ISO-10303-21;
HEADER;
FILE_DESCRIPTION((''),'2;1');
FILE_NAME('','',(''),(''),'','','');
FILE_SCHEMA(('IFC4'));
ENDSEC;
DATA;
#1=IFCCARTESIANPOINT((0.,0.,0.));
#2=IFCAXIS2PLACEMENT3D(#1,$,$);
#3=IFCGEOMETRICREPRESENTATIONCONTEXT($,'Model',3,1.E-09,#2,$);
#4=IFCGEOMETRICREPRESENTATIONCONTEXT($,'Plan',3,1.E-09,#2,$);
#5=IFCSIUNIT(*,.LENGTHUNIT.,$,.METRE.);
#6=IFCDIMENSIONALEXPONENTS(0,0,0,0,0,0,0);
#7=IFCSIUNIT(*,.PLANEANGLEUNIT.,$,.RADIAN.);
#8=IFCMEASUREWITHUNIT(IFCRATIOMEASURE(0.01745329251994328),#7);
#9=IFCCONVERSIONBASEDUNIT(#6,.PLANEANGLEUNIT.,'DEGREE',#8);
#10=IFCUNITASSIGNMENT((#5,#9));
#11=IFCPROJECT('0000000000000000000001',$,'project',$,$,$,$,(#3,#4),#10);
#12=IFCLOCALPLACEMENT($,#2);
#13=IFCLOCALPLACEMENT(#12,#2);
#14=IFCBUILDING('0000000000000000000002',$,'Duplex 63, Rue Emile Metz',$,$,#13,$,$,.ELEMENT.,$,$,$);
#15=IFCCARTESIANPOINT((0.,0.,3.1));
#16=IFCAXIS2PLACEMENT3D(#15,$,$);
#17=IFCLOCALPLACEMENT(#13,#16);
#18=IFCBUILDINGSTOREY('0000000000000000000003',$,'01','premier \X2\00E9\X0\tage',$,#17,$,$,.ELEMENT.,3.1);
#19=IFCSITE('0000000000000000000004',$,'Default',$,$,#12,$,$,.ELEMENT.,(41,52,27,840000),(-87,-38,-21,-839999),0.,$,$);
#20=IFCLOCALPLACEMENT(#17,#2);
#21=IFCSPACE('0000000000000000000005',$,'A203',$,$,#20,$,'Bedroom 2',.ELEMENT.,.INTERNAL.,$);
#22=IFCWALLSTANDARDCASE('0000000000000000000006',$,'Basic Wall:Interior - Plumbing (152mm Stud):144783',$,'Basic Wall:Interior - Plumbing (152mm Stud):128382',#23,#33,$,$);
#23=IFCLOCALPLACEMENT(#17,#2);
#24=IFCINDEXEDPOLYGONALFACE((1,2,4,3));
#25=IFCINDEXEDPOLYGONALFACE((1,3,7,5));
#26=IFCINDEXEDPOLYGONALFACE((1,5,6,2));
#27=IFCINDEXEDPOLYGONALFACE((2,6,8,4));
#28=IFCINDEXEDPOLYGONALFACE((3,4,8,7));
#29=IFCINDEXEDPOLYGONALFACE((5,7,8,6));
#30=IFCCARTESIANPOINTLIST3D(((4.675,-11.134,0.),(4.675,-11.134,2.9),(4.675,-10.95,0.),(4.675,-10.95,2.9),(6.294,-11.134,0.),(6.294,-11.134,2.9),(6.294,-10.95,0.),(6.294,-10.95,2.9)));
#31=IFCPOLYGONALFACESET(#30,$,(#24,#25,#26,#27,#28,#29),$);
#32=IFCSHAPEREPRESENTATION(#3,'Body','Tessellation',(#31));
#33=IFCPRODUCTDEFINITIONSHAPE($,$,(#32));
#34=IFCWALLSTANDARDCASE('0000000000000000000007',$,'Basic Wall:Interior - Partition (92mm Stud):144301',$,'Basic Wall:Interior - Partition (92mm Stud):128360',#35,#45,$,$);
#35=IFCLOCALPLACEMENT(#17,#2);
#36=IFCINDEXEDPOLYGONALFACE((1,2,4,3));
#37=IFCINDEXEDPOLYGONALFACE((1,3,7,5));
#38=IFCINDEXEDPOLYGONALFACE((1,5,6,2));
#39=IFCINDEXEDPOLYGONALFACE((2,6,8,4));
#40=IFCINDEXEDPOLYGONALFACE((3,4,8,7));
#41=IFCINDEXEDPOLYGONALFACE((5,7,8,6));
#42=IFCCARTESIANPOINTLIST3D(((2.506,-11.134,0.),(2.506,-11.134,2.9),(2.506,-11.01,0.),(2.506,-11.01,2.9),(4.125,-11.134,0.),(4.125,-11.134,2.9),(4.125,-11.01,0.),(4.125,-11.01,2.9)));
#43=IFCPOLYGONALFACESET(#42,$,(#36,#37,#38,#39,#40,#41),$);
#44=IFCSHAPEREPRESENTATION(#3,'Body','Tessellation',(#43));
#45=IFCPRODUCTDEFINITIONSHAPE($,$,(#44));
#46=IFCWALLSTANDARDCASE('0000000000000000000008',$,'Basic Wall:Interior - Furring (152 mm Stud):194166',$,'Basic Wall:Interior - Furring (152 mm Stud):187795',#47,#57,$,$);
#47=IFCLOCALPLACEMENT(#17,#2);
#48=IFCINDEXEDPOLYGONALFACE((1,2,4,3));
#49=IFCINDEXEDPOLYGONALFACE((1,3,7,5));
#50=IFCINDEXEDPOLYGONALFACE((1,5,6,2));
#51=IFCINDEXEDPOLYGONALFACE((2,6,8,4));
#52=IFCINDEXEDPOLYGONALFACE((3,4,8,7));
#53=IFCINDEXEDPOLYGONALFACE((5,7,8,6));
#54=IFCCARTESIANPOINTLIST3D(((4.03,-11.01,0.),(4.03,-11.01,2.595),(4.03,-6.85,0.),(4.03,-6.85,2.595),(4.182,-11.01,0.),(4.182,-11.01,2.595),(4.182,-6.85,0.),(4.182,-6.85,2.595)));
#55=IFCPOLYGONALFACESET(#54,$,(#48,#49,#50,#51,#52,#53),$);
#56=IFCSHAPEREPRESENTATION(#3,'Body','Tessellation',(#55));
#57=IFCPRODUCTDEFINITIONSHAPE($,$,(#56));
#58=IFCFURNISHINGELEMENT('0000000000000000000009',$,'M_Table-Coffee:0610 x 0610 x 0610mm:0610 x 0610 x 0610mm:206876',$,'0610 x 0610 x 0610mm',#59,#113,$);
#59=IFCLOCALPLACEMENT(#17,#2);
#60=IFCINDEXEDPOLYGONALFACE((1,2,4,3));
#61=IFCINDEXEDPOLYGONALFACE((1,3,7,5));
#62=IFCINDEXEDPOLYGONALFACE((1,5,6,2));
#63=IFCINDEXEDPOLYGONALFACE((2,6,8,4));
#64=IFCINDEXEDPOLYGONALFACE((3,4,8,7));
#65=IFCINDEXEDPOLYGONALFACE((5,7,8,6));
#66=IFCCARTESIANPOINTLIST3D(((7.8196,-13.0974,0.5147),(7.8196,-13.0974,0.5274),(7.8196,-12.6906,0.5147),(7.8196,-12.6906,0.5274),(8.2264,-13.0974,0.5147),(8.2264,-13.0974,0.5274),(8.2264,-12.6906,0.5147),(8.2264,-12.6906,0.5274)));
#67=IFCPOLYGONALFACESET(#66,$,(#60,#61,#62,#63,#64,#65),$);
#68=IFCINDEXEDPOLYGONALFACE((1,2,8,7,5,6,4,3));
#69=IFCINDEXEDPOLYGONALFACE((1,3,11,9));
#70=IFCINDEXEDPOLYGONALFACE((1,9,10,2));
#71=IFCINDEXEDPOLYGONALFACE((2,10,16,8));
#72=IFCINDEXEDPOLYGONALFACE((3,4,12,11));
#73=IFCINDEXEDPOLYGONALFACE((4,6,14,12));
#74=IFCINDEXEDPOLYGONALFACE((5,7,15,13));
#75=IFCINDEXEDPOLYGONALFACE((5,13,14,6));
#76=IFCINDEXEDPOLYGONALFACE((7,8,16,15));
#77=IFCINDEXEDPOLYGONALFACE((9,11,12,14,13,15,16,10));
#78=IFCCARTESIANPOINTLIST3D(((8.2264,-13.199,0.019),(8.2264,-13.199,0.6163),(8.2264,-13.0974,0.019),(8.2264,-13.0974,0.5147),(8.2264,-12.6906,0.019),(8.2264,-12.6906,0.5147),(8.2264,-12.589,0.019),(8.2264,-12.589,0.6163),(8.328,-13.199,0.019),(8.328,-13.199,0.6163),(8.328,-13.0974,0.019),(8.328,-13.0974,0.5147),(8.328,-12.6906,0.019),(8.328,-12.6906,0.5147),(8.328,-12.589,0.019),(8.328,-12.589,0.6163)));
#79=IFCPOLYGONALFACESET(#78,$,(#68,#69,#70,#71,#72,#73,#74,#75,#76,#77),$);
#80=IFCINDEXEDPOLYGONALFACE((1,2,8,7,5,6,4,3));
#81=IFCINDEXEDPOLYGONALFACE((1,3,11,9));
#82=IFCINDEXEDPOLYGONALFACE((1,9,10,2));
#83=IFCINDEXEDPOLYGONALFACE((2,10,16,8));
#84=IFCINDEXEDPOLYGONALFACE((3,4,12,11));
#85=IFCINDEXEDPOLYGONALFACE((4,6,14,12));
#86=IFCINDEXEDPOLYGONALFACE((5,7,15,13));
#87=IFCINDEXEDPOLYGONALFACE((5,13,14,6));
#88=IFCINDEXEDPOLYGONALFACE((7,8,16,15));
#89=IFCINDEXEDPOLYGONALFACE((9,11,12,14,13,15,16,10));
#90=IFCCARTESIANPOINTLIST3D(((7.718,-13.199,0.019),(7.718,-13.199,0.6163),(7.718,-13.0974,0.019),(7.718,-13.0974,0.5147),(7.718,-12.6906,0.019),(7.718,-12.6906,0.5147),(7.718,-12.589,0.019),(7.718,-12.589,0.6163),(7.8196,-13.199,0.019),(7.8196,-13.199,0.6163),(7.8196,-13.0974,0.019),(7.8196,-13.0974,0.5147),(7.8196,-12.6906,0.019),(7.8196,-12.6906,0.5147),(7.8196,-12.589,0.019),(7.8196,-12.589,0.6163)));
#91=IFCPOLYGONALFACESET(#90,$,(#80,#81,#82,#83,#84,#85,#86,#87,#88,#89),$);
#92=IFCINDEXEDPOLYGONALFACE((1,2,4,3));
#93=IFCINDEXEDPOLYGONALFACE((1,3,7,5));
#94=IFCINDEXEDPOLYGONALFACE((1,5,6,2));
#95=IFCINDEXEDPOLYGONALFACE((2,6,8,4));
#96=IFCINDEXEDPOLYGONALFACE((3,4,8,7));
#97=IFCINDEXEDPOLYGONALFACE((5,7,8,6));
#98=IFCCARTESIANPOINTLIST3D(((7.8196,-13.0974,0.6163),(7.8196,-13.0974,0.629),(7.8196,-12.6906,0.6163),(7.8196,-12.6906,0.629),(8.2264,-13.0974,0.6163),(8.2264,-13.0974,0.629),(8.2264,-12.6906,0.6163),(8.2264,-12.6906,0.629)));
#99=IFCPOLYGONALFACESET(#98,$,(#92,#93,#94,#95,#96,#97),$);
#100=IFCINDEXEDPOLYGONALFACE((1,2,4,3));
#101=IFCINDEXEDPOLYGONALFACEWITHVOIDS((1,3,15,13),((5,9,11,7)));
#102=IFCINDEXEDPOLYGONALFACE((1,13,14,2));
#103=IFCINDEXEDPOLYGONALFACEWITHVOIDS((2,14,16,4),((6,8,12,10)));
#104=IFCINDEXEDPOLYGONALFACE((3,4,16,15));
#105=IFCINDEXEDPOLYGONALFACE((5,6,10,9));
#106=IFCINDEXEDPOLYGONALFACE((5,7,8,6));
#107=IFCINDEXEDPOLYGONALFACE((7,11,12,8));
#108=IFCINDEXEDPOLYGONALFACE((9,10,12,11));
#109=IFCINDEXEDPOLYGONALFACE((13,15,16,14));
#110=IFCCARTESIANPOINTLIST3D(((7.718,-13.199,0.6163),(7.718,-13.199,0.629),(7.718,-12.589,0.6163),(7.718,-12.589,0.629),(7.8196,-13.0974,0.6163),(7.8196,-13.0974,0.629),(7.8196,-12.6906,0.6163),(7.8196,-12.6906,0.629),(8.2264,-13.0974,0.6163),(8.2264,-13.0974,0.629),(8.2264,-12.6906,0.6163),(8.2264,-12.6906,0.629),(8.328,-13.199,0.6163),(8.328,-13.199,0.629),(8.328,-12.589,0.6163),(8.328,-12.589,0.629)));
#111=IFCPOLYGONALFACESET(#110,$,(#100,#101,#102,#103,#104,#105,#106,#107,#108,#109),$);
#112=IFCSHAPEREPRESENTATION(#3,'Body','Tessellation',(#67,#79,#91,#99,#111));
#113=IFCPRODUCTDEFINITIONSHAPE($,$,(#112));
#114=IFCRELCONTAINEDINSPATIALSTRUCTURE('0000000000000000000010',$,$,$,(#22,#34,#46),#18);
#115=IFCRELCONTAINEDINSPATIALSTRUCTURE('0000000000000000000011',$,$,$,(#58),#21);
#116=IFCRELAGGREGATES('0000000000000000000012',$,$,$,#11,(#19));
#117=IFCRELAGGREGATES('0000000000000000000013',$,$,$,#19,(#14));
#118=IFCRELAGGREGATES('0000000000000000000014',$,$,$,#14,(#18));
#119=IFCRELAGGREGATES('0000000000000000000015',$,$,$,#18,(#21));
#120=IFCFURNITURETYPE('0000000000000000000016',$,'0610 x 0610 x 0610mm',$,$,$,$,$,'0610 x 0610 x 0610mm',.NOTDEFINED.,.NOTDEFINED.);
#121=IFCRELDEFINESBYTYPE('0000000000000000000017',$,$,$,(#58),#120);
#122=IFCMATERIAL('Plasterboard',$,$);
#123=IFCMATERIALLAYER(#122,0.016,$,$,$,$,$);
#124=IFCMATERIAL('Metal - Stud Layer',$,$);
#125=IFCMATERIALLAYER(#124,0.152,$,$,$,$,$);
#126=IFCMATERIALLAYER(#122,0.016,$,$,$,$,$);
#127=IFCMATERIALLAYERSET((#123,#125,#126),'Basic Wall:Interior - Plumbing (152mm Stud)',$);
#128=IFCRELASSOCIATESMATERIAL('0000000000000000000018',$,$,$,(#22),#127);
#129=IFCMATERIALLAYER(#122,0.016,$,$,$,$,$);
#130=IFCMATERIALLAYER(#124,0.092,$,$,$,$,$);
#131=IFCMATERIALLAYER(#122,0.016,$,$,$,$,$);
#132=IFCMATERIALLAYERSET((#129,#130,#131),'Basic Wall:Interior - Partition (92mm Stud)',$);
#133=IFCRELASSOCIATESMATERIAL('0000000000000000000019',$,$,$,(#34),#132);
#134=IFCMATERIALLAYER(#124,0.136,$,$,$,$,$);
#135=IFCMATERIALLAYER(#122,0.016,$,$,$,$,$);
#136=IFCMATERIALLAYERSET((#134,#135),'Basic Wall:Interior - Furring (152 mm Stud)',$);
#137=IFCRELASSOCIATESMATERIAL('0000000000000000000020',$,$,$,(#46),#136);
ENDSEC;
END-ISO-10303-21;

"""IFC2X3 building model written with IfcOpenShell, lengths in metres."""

from ifc_helpers import new_model, entity, si_unit, converted_unit, frame, frame_2d, origin, origin_2d_with_axis, place, context, project, spatial, polyline, rectangle, outline, extrude, source, transform, mapped, material, layer, layer_set, layer_usage, type_object, type_shapes, element, save


model = new_model("IFC2X3")

# Units and contexts
model_context = context("Model", 3, precision=1e-09, world=origin())
plan_context = context("Plan", 3, precision=1e-09, world=origin())
ifc_project = project(units=[si_unit("LENGTHUNIT", "METRE"), converted_unit("PLANEANGLEUNIT", "DEGREE", entity("IfcRatioMeasure", 0.01745329251994328), si_unit("PLANEANGLEUNIT", "RADIAN"), dimensions=[0, 0, 0, 0, 0, 0, 0])], contexts=[model_context, plan_context])

# Site, building, storey
site_placement = place(None, origin())
site = spatial("IfcSite", under=ifc_project, at=site_placement, Name="Default", CompositionType="ELEMENT", RefLatitude=(41, 52, 27, 840000), RefLongitude=(-87, -38, -21, -839999), RefElevation=0.0)
building_placement = place(site_placement, origin())
building = spatial("IfcBuilding", under=site, at=building_placement, Name="Duplex 63, Rue Emile Metz", CompositionType="ELEMENT")
storey_placement = place(building_placement, frame((0.0, 0.0, 3.1)))
storey = spatial("IfcBuildingStorey", under=building, at=storey_placement, Name="01", Description="premier étage", CompositionType="ELEMENT", Elevation=3.1)

# Shared definitions
ifc_material_1 = material(Name="Plasterboard")
ifc_layer_1 = layer(ifc_material_1, 0.016)
ifc_material_2 = material(Name="Metal - Stud Layer")
ifc_layer_2 = layer(ifc_material_2, 0.092)
ifc_layer_3 = layer(ifc_material_1, 0.016)
ifc_layer_set_1 = layer_set([ifc_layer_1, ifc_layer_2, ifc_layer_3], Name="Basic Wall:Interior - Partition (92mm Stud)")
ifc_layer_usage_1 = layer_usage(ifc_layer_set_1, "AXIS2", "NEGATIVE", 0.062)

# Walls
ifc_layer_4 = layer(ifc_material_1, 0.016)
ifc_layer_5 = layer(ifc_material_2, 0.152)
ifc_layer_6 = layer(ifc_material_1, 0.016)
ifc_layer_set_2 = layer_set([ifc_layer_4, ifc_layer_5, ifc_layer_6], Name="Basic Wall:Interior - Plumbing (152mm Stud)")
ifc_layer_usage_2 = layer_usage(ifc_layer_set_2, "AXIS2", "NEGATIVE", 0.092)
wall_1_placement = place(storey_placement, frame((6.294, -11.042, 0.0), z_axis=(0.0, 0.0, 1.0), x_axis=(-1.0, 0.0, 0.0)))
element("IfcWallStandardCase", 1, at=wall_1_placement, inside=storey, material=ifc_layer_usage_2, Name="Basic Wall:Interior - Plumbing (152mm Stud):144783", ObjectType="Basic Wall:Interior - Plumbing (152mm Stud):128382", context=model_context, shape_type="SweptSolid", body=[
    extrude(rectangle(XDim=1.619, YDim=0.184, at=frame_2d((0.8095, 0.0), x_axis=(-1.0, 0.0))), origin(), (0.0, 0.0, 1.0), 2.9),
])
wall_2_placement = place(storey_placement, frame((4.125, -11.072, 0.0), z_axis=(0.0, 0.0, 1.0), x_axis=(-1.0, 0.0, 0.0)))
element("IfcWallStandardCase", 2, at=wall_2_placement, inside=storey, material=ifc_layer_usage_1, Name="Basic Wall:Interior - Partition (92mm Stud):144301", ObjectType="Basic Wall:Interior - Partition (92mm Stud):128360", context=model_context, shape_type="SweptSolid", body=[
    extrude(rectangle(XDim=1.619, YDim=0.124, at=frame_2d((0.8095, 0.0), x_axis=(-1.0, 0.0))), origin(), (0.0, 0.0, 1.0), 2.9),
])
ifc_layer_7 = layer(ifc_material_2, 0.136)
ifc_layer_8 = layer(ifc_material_1, 0.016)
ifc_layer_set_3 = layer_set([ifc_layer_7, ifc_layer_8], Name="Basic Wall:Interior - Furring (152 mm Stud)")
ifc_layer_usage_3 = layer_usage(ifc_layer_set_3, "AXIS2", "POSITIVE", -0.076)
wall_3_placement = place(storey_placement, frame((4.106, -11.01, 0.0), z_axis=(0.0, 0.0, 1.0), x_axis=(0.0, 1.0, 0.0)))
element("IfcWallStandardCase", 3, at=wall_3_placement, inside=storey, material=ifc_layer_usage_3, Name="Basic Wall:Interior - Furring (152 mm Stud):194166", ObjectType="Basic Wall:Interior - Furring (152 mm Stud):187795", context=model_context, shape_type="SweptSolid", body=[
    extrude(rectangle(XDim=4.16, YDim=0.152, at=frame_2d((2.08, 0.0), x_axis=(-1.0, 0.0))), origin(), (0.0, 0.0, 1.0), 2.595),
])

# Shared definitions
space_placement = place(storey_placement, origin())
space = spatial("IfcSpace", under=storey, at=space_placement, Name="A203", LongName="Bedroom 2", CompositionType="ELEMENT", InteriorOrExteriorSpace="INTERNAL")

# Furnishing element
furniture_type = type_object("IfcFurnitureType", Name="0610 x 0610 x 0610mm", ElementType="0610 x 0610 x 0610mm", AssemblyPlace="NOTDEFINED")
shared_shape_1 = source(origin(), model_context, "Body", "SweptSolid", [
    extrude(rectangle(XDim=0.4068, YDim=0.4068, at=origin_2d_with_axis()), frame((0.0183, 0.0952, 0.4957), z_axis=(0.0, 0.0, 1.0), x_axis=(-1.0, 0.0, 0.0)), (0.0, 0.0, 1.0), 0.0127),
    extrude(outline(polyline([(-0.2732, -0.305), (0.324, -0.305), (0.324, 0.305), (-0.2732, 0.305), (-0.2732, 0.2034), (0.2225, 0.2034), (0.2225, -0.2034), (-0.2732, -0.2034), (-0.2732, -0.305)])), frame((0.2217, 0.0952, 0.2732), z_axis=(1.0, 0.0, 0.0), x_axis=(0.0, 0.0, 1.0)), (0.0, 0.0, 1.0), 0.1016),
    extrude(outline(polyline([(-0.305, -0.3241), (0.305, -0.3241), (0.305, 0.2733), (0.2034, 0.2733), (0.2034, -0.2224), (-0.2034, -0.2224), (-0.2034, 0.2733), (-0.305, 0.2733), (-0.305, -0.3241)])), frame((-0.2867, 0.0952, 0.2733), z_axis=(1.0, 0.0, 0.0), x_axis=(0.0, -1.0, 0.0)), (0.0, 0.0, 1.0), 0.1016),
    extrude(rectangle(XDim=0.4068, YDim=0.4068, at=origin_2d_with_axis()), frame((0.0183, 0.0952, 0.5973), z_axis=(0.0, 0.0, 1.0), x_axis=(-1.0, 0.0, 0.0)), (0.0, 0.0, 1.0), 0.0127),
    extrude(outline(polyline([(-0.305, -0.305), (0.305, -0.305), (0.305, 0.305), (-0.305, 0.305), (-0.305, -0.305)]), holes=[polyline([(-0.2034, -0.2034), (-0.2034, 0.2034), (0.2034, 0.2034), (0.2034, -0.2034), (-0.2034, -0.2034)])]), frame((0.0183, 0.0952, 0.5973), z_axis=(0.0, 0.0, 1.0), x_axis=(-1.0, 0.0, 0.0)), (0.0, 0.0, 1.0), 0.0127),
])
type_shapes(furniture_type, [shared_shape_1])
furnishing_placement = place(space_placement, frame((8.0047, -12.9892, 0.019)))
element("IfcFurnishingElement", 4, at=furnishing_placement, inside=space, type_object=furniture_type, Name="M_Table-Coffee:0610 x 0610 x 0610mm:0610 x 0610 x 0610mm:206876", ObjectType="0610 x 0610 x 0610mm", context=model_context, shape_type="MappedRepresentation", body=[
    mapped(shared_shape_1, transform((0.0, 0.0, 0.0), scale=1.0)),
])

save(model, "model.ifc")
